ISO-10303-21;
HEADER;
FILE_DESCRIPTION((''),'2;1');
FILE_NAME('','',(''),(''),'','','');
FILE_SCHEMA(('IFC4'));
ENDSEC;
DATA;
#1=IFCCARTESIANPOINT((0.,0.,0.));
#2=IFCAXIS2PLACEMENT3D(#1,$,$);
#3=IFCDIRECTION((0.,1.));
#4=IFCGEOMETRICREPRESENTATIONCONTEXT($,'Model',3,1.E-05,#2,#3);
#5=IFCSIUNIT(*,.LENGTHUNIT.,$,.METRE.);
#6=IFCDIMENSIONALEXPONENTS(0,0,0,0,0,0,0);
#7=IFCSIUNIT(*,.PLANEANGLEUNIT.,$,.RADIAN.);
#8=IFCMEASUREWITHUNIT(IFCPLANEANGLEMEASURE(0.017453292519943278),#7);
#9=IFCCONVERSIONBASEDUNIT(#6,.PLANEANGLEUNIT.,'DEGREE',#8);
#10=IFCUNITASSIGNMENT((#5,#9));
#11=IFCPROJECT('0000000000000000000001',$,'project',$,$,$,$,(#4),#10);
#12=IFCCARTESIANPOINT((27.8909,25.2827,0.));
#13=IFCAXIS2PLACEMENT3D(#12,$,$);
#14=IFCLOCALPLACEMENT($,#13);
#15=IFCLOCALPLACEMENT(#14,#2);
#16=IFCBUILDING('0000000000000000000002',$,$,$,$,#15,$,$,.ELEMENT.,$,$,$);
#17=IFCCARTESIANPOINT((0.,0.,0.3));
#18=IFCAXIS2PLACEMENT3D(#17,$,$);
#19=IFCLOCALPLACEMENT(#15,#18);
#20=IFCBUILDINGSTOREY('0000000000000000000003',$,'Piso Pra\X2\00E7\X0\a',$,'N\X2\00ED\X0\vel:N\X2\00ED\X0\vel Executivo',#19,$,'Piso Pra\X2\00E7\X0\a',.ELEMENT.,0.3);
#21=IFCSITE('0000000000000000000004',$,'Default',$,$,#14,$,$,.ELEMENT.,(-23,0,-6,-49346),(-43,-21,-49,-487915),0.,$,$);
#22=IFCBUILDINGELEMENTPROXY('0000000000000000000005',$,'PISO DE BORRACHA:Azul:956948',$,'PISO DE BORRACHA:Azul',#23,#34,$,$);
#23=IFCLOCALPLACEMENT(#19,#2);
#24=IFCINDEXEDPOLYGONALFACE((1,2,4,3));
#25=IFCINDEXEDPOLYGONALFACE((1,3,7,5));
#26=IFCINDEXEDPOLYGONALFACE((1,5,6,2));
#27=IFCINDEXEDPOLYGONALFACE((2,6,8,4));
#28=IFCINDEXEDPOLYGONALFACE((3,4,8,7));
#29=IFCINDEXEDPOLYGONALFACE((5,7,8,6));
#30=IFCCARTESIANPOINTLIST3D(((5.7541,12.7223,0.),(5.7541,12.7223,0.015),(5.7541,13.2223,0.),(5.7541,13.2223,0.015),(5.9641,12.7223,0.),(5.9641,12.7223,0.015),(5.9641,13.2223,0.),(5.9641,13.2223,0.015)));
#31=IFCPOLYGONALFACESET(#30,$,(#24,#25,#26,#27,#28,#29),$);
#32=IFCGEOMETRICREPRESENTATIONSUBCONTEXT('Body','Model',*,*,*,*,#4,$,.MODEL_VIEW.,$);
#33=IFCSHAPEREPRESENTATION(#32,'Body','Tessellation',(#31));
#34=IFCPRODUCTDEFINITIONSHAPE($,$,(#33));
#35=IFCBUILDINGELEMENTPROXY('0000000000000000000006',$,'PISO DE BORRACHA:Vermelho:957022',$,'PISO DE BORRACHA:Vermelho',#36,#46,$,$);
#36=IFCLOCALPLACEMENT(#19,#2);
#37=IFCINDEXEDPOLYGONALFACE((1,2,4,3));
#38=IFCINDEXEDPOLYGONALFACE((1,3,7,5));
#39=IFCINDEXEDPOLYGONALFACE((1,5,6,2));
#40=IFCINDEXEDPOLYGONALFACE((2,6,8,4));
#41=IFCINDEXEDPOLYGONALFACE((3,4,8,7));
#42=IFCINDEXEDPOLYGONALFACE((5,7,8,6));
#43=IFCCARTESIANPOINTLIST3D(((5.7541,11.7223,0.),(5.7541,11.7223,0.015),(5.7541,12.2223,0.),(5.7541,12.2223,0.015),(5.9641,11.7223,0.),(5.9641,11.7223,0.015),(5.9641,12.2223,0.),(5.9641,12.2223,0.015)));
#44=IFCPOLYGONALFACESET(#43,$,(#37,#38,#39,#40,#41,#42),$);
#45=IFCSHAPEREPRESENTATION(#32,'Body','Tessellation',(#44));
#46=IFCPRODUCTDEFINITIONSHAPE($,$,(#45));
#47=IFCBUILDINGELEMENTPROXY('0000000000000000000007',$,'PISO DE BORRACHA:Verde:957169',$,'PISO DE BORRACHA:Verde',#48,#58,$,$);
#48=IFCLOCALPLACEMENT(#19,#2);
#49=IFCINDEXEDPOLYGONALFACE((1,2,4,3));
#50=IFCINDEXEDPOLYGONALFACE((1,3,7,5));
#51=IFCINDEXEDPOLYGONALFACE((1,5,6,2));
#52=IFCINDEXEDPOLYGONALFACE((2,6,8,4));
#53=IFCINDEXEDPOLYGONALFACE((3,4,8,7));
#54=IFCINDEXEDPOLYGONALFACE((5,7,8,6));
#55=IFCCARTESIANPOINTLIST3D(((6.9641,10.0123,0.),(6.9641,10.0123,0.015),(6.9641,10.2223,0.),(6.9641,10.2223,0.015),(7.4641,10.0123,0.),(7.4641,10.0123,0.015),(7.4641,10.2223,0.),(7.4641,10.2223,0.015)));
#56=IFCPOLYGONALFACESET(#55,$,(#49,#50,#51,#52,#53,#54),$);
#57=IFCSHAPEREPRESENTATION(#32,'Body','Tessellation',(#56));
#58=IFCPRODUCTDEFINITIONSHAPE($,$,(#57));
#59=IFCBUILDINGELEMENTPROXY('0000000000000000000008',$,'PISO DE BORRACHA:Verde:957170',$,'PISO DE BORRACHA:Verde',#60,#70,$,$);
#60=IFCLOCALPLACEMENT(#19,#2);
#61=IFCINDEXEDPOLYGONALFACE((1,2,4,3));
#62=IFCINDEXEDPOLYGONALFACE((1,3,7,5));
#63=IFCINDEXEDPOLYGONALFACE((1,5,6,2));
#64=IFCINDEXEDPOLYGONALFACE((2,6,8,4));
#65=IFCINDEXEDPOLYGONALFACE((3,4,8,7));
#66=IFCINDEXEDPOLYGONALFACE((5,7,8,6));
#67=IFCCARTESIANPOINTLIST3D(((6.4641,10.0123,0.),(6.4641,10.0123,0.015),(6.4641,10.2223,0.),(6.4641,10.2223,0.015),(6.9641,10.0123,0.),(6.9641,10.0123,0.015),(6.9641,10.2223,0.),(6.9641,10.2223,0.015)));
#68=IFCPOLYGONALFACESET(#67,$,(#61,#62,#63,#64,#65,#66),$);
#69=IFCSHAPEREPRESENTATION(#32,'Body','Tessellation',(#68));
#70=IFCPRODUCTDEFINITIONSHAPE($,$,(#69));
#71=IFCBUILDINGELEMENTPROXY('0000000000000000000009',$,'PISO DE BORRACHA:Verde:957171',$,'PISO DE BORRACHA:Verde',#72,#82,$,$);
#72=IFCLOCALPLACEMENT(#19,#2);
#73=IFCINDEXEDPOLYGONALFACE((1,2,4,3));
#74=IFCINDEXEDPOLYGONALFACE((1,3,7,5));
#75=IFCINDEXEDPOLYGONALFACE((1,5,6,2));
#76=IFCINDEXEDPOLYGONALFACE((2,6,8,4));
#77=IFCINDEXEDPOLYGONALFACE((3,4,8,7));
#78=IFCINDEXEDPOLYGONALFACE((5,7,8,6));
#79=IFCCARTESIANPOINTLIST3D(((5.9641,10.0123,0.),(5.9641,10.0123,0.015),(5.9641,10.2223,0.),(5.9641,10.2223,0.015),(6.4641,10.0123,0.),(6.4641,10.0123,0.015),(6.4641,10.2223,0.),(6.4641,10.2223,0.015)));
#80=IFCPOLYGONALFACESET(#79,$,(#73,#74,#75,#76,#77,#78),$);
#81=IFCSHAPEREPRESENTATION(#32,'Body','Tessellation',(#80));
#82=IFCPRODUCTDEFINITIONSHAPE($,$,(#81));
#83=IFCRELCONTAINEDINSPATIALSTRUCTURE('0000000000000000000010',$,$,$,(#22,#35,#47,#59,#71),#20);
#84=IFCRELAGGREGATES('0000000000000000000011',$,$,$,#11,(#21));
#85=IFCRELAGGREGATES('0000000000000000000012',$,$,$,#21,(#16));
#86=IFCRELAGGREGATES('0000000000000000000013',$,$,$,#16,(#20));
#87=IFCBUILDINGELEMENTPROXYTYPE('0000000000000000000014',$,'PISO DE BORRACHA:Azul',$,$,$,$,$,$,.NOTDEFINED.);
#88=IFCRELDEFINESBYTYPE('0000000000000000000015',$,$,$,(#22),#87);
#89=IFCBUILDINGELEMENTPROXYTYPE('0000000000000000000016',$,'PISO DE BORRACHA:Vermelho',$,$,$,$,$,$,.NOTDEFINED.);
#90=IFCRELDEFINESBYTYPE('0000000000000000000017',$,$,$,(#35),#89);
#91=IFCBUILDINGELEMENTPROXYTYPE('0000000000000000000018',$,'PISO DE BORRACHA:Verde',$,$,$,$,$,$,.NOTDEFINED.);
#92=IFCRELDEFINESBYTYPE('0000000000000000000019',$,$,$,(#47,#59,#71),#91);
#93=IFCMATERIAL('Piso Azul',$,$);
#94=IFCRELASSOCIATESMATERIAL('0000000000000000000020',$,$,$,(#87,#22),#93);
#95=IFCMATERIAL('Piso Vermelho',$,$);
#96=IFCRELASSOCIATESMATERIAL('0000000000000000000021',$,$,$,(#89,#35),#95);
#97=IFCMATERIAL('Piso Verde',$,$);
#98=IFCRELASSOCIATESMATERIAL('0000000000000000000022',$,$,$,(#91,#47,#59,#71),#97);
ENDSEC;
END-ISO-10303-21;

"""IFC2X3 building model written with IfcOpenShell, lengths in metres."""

from ifc_helpers import new_model, entity, si_unit, converted_unit, direction, frame, frame_2d, origin, origin_2d_with_axis, place, context, subcontext, project, spatial, rectangle, extrude, source, transform, mapped, material, type_object, type_shapes, element, save


model = new_model("IFC2X3")

# Units and contexts
model_context = context("Model", 3, precision=1e-05, world=origin(), true_north=direction((0.0, 1.0)))
body_context = subcontext(model_context, "Body", "Model", "MODEL_VIEW")
ifc_project = project(units=[si_unit("LENGTHUNIT", "METRE"), converted_unit("PLANEANGLEUNIT", "DEGREE", entity("IfcPlaneAngleMeasure", 0.017453292519943278), si_unit("PLANEANGLEUNIT", "RADIAN"), dimensions=[0, 0, 0, 0, 0, 0, 0])], contexts=[model_context])

# Site, building, storey
site_placement = place(None, frame((27.8909, 25.2827, 0.0)))
site = spatial("IfcSite", under=ifc_project, at=site_placement, Name="Default", CompositionType="ELEMENT", RefLatitude=(-23, 0, -6, -49346), RefLongitude=(-43, -21, -49, -487915), RefElevation=0.0)
building_placement = place(site_placement, origin())
building = spatial("IfcBuilding", under=site, at=building_placement, CompositionType="ELEMENT")
storey_placement = place(building_placement, frame((0.0, 0.0, 0.3)))
storey = spatial("IfcBuildingStorey", under=building, at=storey_placement, Name="Piso Praça", ObjectType="Nível:Nível Executivo", LongName="Piso Praça", CompositionType="ELEMENT", Elevation=0.3)

# Building element proxies
ifc_material_1 = material(Name="Piso Verde")
ifc_material_2 = material(Name="Piso Vermelho")
ifc_material_3 = material(Name="Piso Azul")
building_element_proxy_type_1 = type_object("IfcBuildingElementProxyType", Name="PISO DE BORRACHA:Azul", PredefinedType="NOTDEFINED", material=ifc_material_3)
shared_shape_1 = source(origin(), body_context, "Body", "SweptSolid", [
    extrude(rectangle(XDim=0.21, YDim=0.5, at=frame_2d((0.0, 0.0), x_axis=(1.0, 0.0))), frame((0.105, 0.25, 0.0), z_axis=(0.0, 0.0, 1.0), x_axis=(-1.0, 0.0, 0.0)), (0.0, 0.0, 1.0), 0.015),
])
type_shapes(building_element_proxy_type_1, [shared_shape_1])
proxy_1_placement = place(storey_placement, frame((5.7541, 12.7223, 0.0)))
element("IfcBuildingElementProxy", 1, at=proxy_1_placement, inside=storey, type_object=building_element_proxy_type_1, material=ifc_material_3, Name="PISO DE BORRACHA:Azul:956948", ObjectType="PISO DE BORRACHA:Azul", context=body_context, shape_type="MappedRepresentation", body=[
    mapped(shared_shape_1, transform((0.0, 0.0, 0.0), scale=1.0)),
])
building_element_proxy_type_2 = type_object("IfcBuildingElementProxyType", Name="PISO DE BORRACHA:Vermelho", PredefinedType="NOTDEFINED", material=ifc_material_2)
shared_shape_2 = source(origin(), body_context, "Body", "SweptSolid", [
    extrude(rectangle(XDim=0.21, YDim=0.5, at=frame_2d((0.0, 0.0), x_axis=(1.0, 0.0))), frame((0.105, 0.25, 0.0), z_axis=(0.0, 0.0, 1.0), x_axis=(-1.0, 0.0, 0.0)), (0.0, 0.0, 1.0), 0.015),
])
type_shapes(building_element_proxy_type_2, [shared_shape_2])
proxy_2_placement = place(storey_placement, frame((5.7541, 11.7223, 0.0)))
element("IfcBuildingElementProxy", 2, at=proxy_2_placement, inside=storey, type_object=building_element_proxy_type_2, material=ifc_material_2, Name="PISO DE BORRACHA:Vermelho:957022", ObjectType="PISO DE BORRACHA:Vermelho", context=body_context, shape_type="MappedRepresentation", body=[
    mapped(shared_shape_2, transform((0.0, 0.0, 0.0), scale=1.0)),
])
building_element_proxy_type_3 = type_object("IfcBuildingElementProxyType", Name="PISO DE BORRACHA:Verde", PredefinedType="NOTDEFINED", material=ifc_material_1)
shared_shape_3 = source(origin(), body_context, "Body", "SweptSolid", [
    extrude(rectangle(XDim=0.5, YDim=0.21, at=origin_2d_with_axis()), frame((0.25, 0.105, 0.0), z_axis=(0.0, 0.0, 1.0), x_axis=(-1.0, 0.0, 0.0)), (0.0, 0.0, 1.0), 0.015),
])
type_shapes(building_element_proxy_type_3, [shared_shape_3])
for number, where, name in (
    (3, (6.9641, 10.0123, 0.0), "PISO DE BORRACHA:Verde:957169"),
    (4, (6.4641, 10.0123, 0.0), "PISO DE BORRACHA:Verde:957170"),
    (5, (5.9641, 10.0123, 0.0), "PISO DE BORRACHA:Verde:957171"),
):
    element("IfcBuildingElementProxy", number, at=place(storey_placement, frame(where)), inside=storey, type_object=building_element_proxy_type_3, material=ifc_material_1, Name=name, ObjectType="PISO DE BORRACHA:Verde", context=body_context, shape_type="MappedRepresentation", body=[
        mapped(shared_shape_3, transform((0.0, 0.0, 0.0), scale=1.0)),
    ])

save(model, "model.ifc")
